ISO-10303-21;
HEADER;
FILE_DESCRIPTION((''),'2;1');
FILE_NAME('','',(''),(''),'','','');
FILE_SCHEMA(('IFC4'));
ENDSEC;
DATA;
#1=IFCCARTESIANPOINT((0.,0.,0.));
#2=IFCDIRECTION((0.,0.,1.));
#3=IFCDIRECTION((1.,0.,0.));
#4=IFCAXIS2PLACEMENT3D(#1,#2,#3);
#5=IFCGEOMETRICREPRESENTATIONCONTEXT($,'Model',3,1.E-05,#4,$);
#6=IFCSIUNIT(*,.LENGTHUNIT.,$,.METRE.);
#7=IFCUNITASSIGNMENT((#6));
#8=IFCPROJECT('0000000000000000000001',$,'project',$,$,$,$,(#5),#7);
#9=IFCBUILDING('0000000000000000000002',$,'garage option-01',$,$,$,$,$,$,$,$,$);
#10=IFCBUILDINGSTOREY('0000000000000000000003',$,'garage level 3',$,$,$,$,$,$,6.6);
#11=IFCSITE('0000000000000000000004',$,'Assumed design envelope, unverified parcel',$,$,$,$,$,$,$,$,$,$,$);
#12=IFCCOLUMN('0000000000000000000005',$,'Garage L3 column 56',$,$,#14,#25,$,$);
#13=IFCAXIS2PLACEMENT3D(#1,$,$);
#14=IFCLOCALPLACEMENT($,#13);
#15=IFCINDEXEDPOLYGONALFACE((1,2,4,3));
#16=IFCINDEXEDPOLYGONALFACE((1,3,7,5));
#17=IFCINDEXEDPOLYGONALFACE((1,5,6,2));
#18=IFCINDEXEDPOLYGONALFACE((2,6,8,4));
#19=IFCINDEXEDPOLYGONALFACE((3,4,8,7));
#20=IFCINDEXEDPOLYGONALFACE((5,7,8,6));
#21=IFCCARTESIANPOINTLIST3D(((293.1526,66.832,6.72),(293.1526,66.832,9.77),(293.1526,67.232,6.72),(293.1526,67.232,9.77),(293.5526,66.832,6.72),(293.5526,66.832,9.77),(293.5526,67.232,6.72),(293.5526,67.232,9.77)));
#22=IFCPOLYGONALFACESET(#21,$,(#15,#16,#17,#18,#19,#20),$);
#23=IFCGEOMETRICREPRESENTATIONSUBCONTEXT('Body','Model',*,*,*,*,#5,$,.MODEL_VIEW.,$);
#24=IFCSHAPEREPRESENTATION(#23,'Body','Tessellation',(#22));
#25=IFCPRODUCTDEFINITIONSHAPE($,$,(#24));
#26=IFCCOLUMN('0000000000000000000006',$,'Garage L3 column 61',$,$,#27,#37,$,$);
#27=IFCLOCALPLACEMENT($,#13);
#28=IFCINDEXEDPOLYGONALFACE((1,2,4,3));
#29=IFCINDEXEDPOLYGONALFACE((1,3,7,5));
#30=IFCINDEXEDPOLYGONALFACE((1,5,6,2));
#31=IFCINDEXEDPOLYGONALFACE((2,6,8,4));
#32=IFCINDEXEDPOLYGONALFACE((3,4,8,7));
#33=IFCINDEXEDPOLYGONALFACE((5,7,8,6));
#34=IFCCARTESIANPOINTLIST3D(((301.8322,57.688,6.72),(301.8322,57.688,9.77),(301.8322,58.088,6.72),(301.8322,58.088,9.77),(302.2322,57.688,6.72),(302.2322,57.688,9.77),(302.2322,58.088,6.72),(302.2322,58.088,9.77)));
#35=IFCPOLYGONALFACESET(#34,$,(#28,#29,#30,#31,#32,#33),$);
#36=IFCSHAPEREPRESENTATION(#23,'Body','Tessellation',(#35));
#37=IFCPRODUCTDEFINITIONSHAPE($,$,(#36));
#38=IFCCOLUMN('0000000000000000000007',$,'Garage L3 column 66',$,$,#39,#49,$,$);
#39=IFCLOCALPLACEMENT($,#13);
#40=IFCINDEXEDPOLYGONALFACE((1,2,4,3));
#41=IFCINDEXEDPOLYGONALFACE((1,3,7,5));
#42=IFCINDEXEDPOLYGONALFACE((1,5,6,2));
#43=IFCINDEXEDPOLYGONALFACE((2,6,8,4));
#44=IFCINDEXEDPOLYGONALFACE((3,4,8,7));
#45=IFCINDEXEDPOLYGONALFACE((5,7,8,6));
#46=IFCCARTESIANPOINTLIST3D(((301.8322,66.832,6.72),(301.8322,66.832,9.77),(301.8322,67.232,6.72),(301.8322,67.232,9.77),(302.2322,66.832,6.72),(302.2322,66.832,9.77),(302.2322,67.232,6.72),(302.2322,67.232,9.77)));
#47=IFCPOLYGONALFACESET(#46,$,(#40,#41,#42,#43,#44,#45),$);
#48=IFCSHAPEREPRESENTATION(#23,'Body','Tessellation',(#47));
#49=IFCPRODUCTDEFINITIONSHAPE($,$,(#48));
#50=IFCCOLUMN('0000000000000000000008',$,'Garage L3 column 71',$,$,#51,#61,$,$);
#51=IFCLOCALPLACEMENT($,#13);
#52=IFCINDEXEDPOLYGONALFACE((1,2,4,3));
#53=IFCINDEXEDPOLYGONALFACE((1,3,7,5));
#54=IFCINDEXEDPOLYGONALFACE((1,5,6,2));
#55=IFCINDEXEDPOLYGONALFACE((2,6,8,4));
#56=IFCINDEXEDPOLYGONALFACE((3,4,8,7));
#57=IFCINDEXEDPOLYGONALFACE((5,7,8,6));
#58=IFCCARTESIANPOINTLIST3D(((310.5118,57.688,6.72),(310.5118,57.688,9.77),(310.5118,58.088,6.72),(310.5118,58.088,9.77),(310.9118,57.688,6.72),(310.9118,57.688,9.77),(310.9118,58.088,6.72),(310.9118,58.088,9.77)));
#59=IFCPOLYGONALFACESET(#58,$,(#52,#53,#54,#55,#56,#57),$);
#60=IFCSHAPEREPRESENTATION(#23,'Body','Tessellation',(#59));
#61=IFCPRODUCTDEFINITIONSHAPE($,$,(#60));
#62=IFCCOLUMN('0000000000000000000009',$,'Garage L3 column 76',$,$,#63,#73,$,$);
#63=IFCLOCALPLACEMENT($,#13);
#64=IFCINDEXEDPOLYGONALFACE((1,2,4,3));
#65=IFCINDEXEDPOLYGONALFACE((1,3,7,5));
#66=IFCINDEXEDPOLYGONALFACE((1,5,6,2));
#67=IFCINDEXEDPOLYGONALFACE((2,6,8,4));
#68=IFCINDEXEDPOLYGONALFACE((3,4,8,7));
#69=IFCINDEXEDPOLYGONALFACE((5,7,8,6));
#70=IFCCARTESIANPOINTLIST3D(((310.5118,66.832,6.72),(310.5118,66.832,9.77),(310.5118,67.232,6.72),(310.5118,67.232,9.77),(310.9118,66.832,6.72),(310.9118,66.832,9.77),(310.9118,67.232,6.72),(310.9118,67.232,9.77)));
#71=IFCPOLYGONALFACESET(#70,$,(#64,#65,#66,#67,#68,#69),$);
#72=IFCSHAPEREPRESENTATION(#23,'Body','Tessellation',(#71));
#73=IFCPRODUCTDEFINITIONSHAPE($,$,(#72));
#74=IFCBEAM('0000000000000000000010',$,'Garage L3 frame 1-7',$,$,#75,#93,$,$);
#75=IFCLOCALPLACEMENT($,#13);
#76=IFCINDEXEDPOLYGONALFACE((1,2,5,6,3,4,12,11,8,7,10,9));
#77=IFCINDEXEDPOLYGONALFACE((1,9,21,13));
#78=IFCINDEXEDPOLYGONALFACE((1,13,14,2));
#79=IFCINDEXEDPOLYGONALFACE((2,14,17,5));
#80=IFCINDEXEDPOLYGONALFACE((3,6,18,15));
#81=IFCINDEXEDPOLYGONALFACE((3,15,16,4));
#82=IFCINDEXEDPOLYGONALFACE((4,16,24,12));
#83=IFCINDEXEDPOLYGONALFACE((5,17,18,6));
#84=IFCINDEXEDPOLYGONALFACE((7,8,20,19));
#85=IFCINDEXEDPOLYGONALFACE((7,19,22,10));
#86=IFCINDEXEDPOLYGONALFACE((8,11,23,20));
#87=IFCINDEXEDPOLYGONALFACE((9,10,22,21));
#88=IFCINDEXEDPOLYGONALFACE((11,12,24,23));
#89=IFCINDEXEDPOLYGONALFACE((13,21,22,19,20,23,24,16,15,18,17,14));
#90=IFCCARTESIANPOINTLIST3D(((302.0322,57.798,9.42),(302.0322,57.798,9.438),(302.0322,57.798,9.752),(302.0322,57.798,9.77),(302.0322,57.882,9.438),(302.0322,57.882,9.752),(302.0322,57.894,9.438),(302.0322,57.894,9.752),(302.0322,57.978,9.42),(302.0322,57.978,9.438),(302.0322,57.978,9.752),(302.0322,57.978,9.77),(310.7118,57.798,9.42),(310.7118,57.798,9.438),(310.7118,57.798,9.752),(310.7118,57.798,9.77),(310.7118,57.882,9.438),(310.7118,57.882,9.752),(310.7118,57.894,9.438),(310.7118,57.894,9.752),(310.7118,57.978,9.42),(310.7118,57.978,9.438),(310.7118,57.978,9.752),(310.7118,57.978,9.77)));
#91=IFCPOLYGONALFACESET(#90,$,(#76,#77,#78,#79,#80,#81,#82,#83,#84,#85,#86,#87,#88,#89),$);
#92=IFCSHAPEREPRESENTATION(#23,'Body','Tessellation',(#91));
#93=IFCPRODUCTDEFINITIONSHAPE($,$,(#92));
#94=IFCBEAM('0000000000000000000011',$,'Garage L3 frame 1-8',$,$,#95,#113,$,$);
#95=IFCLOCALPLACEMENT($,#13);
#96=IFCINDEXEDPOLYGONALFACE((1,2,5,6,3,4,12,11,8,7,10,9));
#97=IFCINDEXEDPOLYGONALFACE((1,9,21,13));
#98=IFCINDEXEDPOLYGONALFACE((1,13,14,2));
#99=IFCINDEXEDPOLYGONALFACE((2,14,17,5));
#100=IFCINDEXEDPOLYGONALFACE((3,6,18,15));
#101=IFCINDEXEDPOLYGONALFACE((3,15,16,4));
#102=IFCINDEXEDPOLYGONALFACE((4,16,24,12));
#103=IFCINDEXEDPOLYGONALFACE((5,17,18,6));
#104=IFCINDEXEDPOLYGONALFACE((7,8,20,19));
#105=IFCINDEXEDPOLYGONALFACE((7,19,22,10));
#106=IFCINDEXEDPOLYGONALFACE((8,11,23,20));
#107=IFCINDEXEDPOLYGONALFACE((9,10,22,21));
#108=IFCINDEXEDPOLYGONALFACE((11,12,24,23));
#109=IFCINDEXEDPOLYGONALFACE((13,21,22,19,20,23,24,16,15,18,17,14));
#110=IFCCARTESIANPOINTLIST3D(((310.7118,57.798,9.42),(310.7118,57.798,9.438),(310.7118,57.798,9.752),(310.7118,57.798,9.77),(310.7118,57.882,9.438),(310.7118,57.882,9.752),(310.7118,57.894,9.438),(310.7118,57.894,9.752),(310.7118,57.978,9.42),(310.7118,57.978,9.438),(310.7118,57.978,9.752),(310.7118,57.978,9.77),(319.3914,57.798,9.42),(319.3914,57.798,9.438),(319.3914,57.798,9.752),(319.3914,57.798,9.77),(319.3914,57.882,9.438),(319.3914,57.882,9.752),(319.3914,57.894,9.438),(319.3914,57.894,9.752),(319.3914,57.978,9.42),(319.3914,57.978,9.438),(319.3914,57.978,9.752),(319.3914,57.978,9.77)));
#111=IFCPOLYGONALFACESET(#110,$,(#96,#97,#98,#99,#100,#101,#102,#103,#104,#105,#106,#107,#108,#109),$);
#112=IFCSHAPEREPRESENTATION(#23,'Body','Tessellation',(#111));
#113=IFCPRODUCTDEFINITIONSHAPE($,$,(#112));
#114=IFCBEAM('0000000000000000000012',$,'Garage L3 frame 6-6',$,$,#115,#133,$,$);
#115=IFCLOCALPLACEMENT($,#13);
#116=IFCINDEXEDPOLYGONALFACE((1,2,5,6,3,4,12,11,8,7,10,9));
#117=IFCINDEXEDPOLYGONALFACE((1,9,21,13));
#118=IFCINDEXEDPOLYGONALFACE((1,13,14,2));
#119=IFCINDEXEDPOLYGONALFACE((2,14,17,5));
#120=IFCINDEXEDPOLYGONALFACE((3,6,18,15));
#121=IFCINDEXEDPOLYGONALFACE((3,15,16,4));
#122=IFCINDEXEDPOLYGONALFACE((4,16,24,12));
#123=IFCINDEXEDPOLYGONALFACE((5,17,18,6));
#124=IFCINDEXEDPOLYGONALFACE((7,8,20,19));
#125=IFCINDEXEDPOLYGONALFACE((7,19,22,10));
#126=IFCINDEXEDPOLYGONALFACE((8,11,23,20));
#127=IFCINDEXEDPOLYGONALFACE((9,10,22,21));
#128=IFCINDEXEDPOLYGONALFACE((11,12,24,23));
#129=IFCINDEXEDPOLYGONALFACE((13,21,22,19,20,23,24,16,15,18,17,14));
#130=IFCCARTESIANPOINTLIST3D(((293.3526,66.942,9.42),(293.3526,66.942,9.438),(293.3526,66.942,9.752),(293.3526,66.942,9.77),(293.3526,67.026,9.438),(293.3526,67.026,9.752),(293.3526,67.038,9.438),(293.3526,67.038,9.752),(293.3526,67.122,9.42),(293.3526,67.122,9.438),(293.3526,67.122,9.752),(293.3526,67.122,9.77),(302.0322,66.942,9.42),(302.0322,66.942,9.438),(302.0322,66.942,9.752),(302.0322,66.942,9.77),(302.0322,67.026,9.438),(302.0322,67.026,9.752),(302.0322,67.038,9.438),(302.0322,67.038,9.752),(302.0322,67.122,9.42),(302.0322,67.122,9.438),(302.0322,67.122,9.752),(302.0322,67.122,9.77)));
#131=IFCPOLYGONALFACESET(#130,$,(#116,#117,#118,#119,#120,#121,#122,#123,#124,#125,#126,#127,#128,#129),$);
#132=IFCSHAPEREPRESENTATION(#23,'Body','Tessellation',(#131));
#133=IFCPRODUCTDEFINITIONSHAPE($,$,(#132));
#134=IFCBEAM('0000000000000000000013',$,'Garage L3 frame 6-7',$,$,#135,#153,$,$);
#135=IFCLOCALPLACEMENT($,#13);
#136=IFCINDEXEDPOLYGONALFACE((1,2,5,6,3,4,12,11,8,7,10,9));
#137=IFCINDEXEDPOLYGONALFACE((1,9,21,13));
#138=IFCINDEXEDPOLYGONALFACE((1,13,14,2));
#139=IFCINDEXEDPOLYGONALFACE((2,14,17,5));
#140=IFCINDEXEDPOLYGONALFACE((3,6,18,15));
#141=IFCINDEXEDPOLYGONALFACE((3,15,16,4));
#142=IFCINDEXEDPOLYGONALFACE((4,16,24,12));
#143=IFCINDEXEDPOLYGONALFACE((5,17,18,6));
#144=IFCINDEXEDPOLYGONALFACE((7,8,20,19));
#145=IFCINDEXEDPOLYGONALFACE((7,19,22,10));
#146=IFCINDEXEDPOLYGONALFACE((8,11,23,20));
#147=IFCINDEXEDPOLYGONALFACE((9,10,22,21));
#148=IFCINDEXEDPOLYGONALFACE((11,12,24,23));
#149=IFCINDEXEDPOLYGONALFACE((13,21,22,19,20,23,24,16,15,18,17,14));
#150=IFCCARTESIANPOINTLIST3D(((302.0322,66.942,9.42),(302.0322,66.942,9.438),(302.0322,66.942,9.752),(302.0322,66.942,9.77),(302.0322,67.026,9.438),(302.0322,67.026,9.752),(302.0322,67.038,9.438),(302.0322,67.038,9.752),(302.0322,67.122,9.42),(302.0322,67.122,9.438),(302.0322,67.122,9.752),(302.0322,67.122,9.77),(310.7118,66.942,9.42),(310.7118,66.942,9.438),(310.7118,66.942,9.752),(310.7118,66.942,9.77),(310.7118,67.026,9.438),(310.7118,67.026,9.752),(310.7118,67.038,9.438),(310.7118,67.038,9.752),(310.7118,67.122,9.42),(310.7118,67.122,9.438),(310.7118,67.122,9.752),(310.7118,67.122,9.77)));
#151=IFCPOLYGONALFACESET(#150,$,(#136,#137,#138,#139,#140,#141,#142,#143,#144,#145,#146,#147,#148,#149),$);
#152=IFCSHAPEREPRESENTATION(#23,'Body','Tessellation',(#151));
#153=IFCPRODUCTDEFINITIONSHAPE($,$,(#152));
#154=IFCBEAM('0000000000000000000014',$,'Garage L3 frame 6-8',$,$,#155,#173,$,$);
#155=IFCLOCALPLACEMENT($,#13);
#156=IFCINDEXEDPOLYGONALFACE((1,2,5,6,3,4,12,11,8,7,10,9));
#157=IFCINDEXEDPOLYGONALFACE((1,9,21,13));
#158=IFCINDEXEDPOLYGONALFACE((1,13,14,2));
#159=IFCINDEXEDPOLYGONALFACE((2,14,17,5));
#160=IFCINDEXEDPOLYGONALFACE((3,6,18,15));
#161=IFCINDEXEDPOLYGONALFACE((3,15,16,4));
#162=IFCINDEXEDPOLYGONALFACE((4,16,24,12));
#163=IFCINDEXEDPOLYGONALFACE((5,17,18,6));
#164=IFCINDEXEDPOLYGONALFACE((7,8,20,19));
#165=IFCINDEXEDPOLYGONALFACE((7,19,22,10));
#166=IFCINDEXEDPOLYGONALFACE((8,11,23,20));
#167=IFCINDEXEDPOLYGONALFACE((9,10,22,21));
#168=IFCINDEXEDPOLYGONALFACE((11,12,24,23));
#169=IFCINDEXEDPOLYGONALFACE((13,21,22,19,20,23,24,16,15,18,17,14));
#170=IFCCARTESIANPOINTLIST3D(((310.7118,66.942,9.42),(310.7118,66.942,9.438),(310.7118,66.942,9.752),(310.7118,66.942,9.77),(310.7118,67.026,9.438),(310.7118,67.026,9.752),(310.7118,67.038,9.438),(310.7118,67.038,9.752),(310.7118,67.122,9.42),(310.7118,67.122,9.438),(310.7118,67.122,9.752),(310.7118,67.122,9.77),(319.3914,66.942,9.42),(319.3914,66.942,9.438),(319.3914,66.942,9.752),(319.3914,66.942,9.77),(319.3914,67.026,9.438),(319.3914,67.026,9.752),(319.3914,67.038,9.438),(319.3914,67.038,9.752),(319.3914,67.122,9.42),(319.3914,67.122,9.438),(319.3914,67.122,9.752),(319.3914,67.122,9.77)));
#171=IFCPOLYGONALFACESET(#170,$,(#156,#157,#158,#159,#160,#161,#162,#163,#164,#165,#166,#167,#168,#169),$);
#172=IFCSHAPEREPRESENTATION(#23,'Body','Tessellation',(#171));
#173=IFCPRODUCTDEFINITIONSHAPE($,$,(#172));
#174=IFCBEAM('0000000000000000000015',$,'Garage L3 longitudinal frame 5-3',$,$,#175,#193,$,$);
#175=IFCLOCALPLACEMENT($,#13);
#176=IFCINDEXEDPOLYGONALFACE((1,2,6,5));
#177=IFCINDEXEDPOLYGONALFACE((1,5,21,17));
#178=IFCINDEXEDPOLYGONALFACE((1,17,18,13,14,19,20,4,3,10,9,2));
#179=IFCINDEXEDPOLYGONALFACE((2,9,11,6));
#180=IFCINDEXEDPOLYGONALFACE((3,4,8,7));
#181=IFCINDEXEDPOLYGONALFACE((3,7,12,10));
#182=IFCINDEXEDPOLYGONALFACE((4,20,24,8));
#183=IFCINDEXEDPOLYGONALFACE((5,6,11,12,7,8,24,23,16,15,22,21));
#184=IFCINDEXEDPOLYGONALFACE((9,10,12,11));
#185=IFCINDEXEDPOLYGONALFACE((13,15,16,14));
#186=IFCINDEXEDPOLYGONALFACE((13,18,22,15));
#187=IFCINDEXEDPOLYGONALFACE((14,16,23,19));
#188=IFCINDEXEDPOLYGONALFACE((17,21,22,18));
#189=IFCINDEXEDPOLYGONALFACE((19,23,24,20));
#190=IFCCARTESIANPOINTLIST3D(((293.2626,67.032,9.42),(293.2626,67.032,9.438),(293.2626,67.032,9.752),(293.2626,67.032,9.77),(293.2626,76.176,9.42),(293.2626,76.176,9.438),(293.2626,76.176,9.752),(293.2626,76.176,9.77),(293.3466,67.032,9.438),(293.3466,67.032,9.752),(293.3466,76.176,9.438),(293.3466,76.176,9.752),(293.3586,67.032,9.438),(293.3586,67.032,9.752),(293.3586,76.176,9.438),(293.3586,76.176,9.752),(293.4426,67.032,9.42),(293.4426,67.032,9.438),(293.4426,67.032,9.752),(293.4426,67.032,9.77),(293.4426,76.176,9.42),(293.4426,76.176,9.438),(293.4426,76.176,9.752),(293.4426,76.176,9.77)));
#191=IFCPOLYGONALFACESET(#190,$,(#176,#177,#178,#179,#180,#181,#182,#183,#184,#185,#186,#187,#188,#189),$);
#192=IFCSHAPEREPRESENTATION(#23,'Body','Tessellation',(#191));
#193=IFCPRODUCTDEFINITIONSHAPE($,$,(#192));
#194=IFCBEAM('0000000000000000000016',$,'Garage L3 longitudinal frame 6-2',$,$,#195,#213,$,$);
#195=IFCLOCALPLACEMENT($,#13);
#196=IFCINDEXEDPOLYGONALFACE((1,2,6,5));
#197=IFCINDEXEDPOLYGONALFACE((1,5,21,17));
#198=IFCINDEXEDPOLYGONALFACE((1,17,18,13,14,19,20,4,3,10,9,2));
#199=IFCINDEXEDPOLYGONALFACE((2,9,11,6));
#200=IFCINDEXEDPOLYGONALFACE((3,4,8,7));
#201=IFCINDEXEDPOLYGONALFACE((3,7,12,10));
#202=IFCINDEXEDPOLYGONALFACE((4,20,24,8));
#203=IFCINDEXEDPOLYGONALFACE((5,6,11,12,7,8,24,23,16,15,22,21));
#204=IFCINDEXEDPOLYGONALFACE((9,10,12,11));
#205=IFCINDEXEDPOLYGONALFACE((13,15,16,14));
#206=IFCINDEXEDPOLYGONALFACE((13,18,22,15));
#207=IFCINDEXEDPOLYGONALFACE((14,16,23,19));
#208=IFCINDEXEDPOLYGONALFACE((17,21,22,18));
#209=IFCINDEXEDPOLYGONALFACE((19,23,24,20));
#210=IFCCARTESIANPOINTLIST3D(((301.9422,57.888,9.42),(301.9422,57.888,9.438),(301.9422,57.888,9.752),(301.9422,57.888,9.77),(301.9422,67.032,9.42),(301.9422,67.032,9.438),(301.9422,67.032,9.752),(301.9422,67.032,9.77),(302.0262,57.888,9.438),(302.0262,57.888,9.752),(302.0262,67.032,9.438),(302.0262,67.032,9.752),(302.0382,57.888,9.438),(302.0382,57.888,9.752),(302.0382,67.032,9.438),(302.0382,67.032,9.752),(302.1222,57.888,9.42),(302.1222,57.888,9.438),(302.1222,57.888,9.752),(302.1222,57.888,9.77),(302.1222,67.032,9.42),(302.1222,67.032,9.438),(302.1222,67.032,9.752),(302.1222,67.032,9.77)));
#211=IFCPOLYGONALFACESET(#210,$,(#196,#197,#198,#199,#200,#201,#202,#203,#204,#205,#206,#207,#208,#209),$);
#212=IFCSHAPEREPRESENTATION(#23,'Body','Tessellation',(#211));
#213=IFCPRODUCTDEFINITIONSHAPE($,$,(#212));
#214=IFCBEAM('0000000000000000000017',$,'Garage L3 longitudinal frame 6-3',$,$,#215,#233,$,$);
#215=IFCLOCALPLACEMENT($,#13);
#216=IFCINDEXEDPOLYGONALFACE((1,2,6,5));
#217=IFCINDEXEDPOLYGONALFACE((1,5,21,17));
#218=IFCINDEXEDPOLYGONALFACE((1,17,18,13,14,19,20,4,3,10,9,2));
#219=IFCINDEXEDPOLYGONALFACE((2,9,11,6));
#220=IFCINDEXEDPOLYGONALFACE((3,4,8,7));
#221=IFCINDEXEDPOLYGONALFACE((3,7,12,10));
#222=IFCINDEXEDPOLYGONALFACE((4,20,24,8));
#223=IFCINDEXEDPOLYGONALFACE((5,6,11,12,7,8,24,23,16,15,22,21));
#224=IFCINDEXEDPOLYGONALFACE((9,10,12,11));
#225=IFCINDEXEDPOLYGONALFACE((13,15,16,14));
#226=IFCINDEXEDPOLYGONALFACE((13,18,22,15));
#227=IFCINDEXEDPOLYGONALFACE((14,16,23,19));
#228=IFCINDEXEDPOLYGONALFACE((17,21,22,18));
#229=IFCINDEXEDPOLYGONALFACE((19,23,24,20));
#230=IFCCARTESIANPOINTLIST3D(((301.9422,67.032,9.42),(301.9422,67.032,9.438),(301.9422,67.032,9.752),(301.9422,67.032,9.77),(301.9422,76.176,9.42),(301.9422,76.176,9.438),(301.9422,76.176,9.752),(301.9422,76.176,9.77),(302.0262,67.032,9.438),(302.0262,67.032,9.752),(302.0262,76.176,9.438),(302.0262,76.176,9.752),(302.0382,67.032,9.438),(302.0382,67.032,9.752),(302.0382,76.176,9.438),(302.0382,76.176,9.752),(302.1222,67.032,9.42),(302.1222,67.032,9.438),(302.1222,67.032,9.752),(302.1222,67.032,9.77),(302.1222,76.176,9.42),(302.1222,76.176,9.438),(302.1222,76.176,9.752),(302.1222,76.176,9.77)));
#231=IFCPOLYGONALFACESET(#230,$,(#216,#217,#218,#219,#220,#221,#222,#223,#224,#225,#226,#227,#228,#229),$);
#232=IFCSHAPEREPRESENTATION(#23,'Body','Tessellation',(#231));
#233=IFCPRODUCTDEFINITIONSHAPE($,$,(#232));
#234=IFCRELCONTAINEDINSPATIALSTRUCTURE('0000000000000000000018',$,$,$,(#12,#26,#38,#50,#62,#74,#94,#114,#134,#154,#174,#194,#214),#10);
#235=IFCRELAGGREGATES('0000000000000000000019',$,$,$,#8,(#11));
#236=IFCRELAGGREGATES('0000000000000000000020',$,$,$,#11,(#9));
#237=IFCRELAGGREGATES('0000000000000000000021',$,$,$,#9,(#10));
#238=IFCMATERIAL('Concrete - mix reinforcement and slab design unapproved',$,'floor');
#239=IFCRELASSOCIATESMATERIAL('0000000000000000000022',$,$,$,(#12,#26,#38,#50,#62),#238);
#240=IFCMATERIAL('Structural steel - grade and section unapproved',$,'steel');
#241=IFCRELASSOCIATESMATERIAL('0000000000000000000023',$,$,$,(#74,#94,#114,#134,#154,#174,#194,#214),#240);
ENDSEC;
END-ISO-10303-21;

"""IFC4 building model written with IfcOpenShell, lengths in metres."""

from ifc_helpers import new_model, si_unit, frame, origin_with_axes, place, context, subcontext, project, spatial, rectangle, i_section, extrude, material, element, save


model = new_model("IFC4")

# Units and contexts
model_context = context("Model", 3, precision=1e-05, world=origin_with_axes())
body_context = subcontext(model_context, "Body", "Model", "MODEL_VIEW")
ifc_project = project(units=[si_unit("LENGTHUNIT", "METRE")], contexts=[model_context])

# Site, building, storey
site = spatial("IfcSite", under=ifc_project, Name="Assumed design envelope, unverified parcel")
building = spatial("IfcBuilding", under=site, Name="garage option-01")
storey = spatial("IfcBuildingStorey", under=building, Name="garage level 3", Elevation=6.6)

# Columns
ifc_material_1 = material(Name="Concrete - mix reinforcement and slab design unapproved", Category="floor")
for number, where, z_axis, x_axis, name in (
    (1, (293.3526, 67.032, 6.72), (0.0, 0.0, 1.0), (1.0, 0.0, 0.0), "Garage L3 column 56"),
    (2, (302.0322, 57.888, 6.72), (0.0, 0.0, 1.0), (1.0, 0.0, 0.0), "Garage L3 column 61"),
    (3, (302.0322, 67.032, 6.72), (0.0, 0.0, 1.0), (1.0, 0.0, 0.0), "Garage L3 column 66"),
    (4, (310.7118, 57.888, 6.72), (0.0, 0.0, 1.0), (1.0, 0.0, 0.0), "Garage L3 column 71"),
    (5, (310.7118, 67.032, 6.72), (0.0, 0.0, 1.0), (1.0, 0.0, 0.0), "Garage L3 column 76"),
):
    element("IfcColumn", number, at=place(None, frame(where, z_axis=z_axis, x_axis=x_axis)), inside=storey, material=ifc_material_1, Name=name, context=body_context, shape_type="SweptSolid", body=[
        extrude(rectangle(XDim=0.4, YDim=0.4), origin_with_axes(), (0.0, 0.0, 1.0), 3.05),
    ])

# Beams
ifc_material_2 = material(Name="Structural steel - grade and section unapproved", Category="steel")
for number, where, z_axis, x_axis, name in (
    (6, (302.0322, 57.888, 9.595), (1.0, 0.0, 0.0), (0.0, 1.0, 0.0), "Garage L3 frame 1-7"),
    (7, (310.7118, 57.888, 9.595), (1.0, 0.0, 0.0), (0.0, 1.0, 0.0), "Garage L3 frame 1-8"),
    (8, (293.3526, 67.032, 9.595), (1.0, 0.0, 0.0), (0.0, 1.0, 0.0), "Garage L3 frame 6-6"),
    (9, (302.0322, 67.032, 9.595), (1.0, 0.0, 0.0), (0.0, 1.0, 0.0), "Garage L3 frame 6-7"),
    (10, (310.7118, 67.032, 9.595), (1.0, 0.0, 0.0), (0.0, 1.0, 0.0), "Garage L3 frame 6-8"),
):
    element("IfcBeam", number, at=place(None, frame(where, z_axis=z_axis, x_axis=x_axis)), inside=storey, material=ifc_material_2, Name=name, context=body_context, shape_type="SweptSolid", body=[
        extrude(i_section(OverallWidth=0.18, OverallDepth=0.35, WebThickness=0.012, FlangeThickness=0.018, FilletRadius=0.0), origin_with_axes(), (0.0, 0.0, 1.0), 8.6796),
    ])
beam_1_placement = place(None, frame((293.3526, 67.032, 9.595), z_axis=(0.0, 1.0, 0.0), x_axis=(-1.0, 0.0, 0.0)))
element("IfcBeam", 11, at=beam_1_placement, inside=storey, material=ifc_material_2, Name="Garage L3 longitudinal frame 5-3", context=body_context, shape_type="SweptSolid", body=[
    extrude(i_section(OverallWidth=0.18, OverallDepth=0.35, WebThickness=0.012, FlangeThickness=0.018, FilletRadius=0.0), origin_with_axes(), (0.0, 0.0, 1.0), 9.144),
])
beam_2_placement = place(None, frame((302.0322, 57.888, 9.595), z_axis=(0.0, 1.0, 0.0), x_axis=(-1.0, 0.0, 0.0)))
element("IfcBeam", 12, at=beam_2_placement, inside=storey, material=ifc_material_2, Name="Garage L3 longitudinal frame 6-2", context=body_context, shape_type="SweptSolid", body=[
    extrude(i_section(OverallWidth=0.18, OverallDepth=0.35, WebThickness=0.012, FlangeThickness=0.018, FilletRadius=0.0), origin_with_axes(), (0.0, 0.0, 1.0), 9.144),
])
beam_3_placement = place(None, frame((302.0322, 67.032, 9.595), z_axis=(0.0, 1.0, 0.0), x_axis=(-1.0, 0.0, 0.0)))
element("IfcBeam", 13, at=beam_3_placement, inside=storey, material=ifc_material_2, Name="Garage L3 longitudinal frame 6-3", context=body_context, shape_type="SweptSolid", body=[
    extrude(i_section(OverallWidth=0.18, OverallDepth=0.35, WebThickness=0.012, FlangeThickness=0.018, FilletRadius=0.0), origin_with_axes(), (0.0, 0.0, 1.0), 9.144),
])

save(model, "model.ifc")
